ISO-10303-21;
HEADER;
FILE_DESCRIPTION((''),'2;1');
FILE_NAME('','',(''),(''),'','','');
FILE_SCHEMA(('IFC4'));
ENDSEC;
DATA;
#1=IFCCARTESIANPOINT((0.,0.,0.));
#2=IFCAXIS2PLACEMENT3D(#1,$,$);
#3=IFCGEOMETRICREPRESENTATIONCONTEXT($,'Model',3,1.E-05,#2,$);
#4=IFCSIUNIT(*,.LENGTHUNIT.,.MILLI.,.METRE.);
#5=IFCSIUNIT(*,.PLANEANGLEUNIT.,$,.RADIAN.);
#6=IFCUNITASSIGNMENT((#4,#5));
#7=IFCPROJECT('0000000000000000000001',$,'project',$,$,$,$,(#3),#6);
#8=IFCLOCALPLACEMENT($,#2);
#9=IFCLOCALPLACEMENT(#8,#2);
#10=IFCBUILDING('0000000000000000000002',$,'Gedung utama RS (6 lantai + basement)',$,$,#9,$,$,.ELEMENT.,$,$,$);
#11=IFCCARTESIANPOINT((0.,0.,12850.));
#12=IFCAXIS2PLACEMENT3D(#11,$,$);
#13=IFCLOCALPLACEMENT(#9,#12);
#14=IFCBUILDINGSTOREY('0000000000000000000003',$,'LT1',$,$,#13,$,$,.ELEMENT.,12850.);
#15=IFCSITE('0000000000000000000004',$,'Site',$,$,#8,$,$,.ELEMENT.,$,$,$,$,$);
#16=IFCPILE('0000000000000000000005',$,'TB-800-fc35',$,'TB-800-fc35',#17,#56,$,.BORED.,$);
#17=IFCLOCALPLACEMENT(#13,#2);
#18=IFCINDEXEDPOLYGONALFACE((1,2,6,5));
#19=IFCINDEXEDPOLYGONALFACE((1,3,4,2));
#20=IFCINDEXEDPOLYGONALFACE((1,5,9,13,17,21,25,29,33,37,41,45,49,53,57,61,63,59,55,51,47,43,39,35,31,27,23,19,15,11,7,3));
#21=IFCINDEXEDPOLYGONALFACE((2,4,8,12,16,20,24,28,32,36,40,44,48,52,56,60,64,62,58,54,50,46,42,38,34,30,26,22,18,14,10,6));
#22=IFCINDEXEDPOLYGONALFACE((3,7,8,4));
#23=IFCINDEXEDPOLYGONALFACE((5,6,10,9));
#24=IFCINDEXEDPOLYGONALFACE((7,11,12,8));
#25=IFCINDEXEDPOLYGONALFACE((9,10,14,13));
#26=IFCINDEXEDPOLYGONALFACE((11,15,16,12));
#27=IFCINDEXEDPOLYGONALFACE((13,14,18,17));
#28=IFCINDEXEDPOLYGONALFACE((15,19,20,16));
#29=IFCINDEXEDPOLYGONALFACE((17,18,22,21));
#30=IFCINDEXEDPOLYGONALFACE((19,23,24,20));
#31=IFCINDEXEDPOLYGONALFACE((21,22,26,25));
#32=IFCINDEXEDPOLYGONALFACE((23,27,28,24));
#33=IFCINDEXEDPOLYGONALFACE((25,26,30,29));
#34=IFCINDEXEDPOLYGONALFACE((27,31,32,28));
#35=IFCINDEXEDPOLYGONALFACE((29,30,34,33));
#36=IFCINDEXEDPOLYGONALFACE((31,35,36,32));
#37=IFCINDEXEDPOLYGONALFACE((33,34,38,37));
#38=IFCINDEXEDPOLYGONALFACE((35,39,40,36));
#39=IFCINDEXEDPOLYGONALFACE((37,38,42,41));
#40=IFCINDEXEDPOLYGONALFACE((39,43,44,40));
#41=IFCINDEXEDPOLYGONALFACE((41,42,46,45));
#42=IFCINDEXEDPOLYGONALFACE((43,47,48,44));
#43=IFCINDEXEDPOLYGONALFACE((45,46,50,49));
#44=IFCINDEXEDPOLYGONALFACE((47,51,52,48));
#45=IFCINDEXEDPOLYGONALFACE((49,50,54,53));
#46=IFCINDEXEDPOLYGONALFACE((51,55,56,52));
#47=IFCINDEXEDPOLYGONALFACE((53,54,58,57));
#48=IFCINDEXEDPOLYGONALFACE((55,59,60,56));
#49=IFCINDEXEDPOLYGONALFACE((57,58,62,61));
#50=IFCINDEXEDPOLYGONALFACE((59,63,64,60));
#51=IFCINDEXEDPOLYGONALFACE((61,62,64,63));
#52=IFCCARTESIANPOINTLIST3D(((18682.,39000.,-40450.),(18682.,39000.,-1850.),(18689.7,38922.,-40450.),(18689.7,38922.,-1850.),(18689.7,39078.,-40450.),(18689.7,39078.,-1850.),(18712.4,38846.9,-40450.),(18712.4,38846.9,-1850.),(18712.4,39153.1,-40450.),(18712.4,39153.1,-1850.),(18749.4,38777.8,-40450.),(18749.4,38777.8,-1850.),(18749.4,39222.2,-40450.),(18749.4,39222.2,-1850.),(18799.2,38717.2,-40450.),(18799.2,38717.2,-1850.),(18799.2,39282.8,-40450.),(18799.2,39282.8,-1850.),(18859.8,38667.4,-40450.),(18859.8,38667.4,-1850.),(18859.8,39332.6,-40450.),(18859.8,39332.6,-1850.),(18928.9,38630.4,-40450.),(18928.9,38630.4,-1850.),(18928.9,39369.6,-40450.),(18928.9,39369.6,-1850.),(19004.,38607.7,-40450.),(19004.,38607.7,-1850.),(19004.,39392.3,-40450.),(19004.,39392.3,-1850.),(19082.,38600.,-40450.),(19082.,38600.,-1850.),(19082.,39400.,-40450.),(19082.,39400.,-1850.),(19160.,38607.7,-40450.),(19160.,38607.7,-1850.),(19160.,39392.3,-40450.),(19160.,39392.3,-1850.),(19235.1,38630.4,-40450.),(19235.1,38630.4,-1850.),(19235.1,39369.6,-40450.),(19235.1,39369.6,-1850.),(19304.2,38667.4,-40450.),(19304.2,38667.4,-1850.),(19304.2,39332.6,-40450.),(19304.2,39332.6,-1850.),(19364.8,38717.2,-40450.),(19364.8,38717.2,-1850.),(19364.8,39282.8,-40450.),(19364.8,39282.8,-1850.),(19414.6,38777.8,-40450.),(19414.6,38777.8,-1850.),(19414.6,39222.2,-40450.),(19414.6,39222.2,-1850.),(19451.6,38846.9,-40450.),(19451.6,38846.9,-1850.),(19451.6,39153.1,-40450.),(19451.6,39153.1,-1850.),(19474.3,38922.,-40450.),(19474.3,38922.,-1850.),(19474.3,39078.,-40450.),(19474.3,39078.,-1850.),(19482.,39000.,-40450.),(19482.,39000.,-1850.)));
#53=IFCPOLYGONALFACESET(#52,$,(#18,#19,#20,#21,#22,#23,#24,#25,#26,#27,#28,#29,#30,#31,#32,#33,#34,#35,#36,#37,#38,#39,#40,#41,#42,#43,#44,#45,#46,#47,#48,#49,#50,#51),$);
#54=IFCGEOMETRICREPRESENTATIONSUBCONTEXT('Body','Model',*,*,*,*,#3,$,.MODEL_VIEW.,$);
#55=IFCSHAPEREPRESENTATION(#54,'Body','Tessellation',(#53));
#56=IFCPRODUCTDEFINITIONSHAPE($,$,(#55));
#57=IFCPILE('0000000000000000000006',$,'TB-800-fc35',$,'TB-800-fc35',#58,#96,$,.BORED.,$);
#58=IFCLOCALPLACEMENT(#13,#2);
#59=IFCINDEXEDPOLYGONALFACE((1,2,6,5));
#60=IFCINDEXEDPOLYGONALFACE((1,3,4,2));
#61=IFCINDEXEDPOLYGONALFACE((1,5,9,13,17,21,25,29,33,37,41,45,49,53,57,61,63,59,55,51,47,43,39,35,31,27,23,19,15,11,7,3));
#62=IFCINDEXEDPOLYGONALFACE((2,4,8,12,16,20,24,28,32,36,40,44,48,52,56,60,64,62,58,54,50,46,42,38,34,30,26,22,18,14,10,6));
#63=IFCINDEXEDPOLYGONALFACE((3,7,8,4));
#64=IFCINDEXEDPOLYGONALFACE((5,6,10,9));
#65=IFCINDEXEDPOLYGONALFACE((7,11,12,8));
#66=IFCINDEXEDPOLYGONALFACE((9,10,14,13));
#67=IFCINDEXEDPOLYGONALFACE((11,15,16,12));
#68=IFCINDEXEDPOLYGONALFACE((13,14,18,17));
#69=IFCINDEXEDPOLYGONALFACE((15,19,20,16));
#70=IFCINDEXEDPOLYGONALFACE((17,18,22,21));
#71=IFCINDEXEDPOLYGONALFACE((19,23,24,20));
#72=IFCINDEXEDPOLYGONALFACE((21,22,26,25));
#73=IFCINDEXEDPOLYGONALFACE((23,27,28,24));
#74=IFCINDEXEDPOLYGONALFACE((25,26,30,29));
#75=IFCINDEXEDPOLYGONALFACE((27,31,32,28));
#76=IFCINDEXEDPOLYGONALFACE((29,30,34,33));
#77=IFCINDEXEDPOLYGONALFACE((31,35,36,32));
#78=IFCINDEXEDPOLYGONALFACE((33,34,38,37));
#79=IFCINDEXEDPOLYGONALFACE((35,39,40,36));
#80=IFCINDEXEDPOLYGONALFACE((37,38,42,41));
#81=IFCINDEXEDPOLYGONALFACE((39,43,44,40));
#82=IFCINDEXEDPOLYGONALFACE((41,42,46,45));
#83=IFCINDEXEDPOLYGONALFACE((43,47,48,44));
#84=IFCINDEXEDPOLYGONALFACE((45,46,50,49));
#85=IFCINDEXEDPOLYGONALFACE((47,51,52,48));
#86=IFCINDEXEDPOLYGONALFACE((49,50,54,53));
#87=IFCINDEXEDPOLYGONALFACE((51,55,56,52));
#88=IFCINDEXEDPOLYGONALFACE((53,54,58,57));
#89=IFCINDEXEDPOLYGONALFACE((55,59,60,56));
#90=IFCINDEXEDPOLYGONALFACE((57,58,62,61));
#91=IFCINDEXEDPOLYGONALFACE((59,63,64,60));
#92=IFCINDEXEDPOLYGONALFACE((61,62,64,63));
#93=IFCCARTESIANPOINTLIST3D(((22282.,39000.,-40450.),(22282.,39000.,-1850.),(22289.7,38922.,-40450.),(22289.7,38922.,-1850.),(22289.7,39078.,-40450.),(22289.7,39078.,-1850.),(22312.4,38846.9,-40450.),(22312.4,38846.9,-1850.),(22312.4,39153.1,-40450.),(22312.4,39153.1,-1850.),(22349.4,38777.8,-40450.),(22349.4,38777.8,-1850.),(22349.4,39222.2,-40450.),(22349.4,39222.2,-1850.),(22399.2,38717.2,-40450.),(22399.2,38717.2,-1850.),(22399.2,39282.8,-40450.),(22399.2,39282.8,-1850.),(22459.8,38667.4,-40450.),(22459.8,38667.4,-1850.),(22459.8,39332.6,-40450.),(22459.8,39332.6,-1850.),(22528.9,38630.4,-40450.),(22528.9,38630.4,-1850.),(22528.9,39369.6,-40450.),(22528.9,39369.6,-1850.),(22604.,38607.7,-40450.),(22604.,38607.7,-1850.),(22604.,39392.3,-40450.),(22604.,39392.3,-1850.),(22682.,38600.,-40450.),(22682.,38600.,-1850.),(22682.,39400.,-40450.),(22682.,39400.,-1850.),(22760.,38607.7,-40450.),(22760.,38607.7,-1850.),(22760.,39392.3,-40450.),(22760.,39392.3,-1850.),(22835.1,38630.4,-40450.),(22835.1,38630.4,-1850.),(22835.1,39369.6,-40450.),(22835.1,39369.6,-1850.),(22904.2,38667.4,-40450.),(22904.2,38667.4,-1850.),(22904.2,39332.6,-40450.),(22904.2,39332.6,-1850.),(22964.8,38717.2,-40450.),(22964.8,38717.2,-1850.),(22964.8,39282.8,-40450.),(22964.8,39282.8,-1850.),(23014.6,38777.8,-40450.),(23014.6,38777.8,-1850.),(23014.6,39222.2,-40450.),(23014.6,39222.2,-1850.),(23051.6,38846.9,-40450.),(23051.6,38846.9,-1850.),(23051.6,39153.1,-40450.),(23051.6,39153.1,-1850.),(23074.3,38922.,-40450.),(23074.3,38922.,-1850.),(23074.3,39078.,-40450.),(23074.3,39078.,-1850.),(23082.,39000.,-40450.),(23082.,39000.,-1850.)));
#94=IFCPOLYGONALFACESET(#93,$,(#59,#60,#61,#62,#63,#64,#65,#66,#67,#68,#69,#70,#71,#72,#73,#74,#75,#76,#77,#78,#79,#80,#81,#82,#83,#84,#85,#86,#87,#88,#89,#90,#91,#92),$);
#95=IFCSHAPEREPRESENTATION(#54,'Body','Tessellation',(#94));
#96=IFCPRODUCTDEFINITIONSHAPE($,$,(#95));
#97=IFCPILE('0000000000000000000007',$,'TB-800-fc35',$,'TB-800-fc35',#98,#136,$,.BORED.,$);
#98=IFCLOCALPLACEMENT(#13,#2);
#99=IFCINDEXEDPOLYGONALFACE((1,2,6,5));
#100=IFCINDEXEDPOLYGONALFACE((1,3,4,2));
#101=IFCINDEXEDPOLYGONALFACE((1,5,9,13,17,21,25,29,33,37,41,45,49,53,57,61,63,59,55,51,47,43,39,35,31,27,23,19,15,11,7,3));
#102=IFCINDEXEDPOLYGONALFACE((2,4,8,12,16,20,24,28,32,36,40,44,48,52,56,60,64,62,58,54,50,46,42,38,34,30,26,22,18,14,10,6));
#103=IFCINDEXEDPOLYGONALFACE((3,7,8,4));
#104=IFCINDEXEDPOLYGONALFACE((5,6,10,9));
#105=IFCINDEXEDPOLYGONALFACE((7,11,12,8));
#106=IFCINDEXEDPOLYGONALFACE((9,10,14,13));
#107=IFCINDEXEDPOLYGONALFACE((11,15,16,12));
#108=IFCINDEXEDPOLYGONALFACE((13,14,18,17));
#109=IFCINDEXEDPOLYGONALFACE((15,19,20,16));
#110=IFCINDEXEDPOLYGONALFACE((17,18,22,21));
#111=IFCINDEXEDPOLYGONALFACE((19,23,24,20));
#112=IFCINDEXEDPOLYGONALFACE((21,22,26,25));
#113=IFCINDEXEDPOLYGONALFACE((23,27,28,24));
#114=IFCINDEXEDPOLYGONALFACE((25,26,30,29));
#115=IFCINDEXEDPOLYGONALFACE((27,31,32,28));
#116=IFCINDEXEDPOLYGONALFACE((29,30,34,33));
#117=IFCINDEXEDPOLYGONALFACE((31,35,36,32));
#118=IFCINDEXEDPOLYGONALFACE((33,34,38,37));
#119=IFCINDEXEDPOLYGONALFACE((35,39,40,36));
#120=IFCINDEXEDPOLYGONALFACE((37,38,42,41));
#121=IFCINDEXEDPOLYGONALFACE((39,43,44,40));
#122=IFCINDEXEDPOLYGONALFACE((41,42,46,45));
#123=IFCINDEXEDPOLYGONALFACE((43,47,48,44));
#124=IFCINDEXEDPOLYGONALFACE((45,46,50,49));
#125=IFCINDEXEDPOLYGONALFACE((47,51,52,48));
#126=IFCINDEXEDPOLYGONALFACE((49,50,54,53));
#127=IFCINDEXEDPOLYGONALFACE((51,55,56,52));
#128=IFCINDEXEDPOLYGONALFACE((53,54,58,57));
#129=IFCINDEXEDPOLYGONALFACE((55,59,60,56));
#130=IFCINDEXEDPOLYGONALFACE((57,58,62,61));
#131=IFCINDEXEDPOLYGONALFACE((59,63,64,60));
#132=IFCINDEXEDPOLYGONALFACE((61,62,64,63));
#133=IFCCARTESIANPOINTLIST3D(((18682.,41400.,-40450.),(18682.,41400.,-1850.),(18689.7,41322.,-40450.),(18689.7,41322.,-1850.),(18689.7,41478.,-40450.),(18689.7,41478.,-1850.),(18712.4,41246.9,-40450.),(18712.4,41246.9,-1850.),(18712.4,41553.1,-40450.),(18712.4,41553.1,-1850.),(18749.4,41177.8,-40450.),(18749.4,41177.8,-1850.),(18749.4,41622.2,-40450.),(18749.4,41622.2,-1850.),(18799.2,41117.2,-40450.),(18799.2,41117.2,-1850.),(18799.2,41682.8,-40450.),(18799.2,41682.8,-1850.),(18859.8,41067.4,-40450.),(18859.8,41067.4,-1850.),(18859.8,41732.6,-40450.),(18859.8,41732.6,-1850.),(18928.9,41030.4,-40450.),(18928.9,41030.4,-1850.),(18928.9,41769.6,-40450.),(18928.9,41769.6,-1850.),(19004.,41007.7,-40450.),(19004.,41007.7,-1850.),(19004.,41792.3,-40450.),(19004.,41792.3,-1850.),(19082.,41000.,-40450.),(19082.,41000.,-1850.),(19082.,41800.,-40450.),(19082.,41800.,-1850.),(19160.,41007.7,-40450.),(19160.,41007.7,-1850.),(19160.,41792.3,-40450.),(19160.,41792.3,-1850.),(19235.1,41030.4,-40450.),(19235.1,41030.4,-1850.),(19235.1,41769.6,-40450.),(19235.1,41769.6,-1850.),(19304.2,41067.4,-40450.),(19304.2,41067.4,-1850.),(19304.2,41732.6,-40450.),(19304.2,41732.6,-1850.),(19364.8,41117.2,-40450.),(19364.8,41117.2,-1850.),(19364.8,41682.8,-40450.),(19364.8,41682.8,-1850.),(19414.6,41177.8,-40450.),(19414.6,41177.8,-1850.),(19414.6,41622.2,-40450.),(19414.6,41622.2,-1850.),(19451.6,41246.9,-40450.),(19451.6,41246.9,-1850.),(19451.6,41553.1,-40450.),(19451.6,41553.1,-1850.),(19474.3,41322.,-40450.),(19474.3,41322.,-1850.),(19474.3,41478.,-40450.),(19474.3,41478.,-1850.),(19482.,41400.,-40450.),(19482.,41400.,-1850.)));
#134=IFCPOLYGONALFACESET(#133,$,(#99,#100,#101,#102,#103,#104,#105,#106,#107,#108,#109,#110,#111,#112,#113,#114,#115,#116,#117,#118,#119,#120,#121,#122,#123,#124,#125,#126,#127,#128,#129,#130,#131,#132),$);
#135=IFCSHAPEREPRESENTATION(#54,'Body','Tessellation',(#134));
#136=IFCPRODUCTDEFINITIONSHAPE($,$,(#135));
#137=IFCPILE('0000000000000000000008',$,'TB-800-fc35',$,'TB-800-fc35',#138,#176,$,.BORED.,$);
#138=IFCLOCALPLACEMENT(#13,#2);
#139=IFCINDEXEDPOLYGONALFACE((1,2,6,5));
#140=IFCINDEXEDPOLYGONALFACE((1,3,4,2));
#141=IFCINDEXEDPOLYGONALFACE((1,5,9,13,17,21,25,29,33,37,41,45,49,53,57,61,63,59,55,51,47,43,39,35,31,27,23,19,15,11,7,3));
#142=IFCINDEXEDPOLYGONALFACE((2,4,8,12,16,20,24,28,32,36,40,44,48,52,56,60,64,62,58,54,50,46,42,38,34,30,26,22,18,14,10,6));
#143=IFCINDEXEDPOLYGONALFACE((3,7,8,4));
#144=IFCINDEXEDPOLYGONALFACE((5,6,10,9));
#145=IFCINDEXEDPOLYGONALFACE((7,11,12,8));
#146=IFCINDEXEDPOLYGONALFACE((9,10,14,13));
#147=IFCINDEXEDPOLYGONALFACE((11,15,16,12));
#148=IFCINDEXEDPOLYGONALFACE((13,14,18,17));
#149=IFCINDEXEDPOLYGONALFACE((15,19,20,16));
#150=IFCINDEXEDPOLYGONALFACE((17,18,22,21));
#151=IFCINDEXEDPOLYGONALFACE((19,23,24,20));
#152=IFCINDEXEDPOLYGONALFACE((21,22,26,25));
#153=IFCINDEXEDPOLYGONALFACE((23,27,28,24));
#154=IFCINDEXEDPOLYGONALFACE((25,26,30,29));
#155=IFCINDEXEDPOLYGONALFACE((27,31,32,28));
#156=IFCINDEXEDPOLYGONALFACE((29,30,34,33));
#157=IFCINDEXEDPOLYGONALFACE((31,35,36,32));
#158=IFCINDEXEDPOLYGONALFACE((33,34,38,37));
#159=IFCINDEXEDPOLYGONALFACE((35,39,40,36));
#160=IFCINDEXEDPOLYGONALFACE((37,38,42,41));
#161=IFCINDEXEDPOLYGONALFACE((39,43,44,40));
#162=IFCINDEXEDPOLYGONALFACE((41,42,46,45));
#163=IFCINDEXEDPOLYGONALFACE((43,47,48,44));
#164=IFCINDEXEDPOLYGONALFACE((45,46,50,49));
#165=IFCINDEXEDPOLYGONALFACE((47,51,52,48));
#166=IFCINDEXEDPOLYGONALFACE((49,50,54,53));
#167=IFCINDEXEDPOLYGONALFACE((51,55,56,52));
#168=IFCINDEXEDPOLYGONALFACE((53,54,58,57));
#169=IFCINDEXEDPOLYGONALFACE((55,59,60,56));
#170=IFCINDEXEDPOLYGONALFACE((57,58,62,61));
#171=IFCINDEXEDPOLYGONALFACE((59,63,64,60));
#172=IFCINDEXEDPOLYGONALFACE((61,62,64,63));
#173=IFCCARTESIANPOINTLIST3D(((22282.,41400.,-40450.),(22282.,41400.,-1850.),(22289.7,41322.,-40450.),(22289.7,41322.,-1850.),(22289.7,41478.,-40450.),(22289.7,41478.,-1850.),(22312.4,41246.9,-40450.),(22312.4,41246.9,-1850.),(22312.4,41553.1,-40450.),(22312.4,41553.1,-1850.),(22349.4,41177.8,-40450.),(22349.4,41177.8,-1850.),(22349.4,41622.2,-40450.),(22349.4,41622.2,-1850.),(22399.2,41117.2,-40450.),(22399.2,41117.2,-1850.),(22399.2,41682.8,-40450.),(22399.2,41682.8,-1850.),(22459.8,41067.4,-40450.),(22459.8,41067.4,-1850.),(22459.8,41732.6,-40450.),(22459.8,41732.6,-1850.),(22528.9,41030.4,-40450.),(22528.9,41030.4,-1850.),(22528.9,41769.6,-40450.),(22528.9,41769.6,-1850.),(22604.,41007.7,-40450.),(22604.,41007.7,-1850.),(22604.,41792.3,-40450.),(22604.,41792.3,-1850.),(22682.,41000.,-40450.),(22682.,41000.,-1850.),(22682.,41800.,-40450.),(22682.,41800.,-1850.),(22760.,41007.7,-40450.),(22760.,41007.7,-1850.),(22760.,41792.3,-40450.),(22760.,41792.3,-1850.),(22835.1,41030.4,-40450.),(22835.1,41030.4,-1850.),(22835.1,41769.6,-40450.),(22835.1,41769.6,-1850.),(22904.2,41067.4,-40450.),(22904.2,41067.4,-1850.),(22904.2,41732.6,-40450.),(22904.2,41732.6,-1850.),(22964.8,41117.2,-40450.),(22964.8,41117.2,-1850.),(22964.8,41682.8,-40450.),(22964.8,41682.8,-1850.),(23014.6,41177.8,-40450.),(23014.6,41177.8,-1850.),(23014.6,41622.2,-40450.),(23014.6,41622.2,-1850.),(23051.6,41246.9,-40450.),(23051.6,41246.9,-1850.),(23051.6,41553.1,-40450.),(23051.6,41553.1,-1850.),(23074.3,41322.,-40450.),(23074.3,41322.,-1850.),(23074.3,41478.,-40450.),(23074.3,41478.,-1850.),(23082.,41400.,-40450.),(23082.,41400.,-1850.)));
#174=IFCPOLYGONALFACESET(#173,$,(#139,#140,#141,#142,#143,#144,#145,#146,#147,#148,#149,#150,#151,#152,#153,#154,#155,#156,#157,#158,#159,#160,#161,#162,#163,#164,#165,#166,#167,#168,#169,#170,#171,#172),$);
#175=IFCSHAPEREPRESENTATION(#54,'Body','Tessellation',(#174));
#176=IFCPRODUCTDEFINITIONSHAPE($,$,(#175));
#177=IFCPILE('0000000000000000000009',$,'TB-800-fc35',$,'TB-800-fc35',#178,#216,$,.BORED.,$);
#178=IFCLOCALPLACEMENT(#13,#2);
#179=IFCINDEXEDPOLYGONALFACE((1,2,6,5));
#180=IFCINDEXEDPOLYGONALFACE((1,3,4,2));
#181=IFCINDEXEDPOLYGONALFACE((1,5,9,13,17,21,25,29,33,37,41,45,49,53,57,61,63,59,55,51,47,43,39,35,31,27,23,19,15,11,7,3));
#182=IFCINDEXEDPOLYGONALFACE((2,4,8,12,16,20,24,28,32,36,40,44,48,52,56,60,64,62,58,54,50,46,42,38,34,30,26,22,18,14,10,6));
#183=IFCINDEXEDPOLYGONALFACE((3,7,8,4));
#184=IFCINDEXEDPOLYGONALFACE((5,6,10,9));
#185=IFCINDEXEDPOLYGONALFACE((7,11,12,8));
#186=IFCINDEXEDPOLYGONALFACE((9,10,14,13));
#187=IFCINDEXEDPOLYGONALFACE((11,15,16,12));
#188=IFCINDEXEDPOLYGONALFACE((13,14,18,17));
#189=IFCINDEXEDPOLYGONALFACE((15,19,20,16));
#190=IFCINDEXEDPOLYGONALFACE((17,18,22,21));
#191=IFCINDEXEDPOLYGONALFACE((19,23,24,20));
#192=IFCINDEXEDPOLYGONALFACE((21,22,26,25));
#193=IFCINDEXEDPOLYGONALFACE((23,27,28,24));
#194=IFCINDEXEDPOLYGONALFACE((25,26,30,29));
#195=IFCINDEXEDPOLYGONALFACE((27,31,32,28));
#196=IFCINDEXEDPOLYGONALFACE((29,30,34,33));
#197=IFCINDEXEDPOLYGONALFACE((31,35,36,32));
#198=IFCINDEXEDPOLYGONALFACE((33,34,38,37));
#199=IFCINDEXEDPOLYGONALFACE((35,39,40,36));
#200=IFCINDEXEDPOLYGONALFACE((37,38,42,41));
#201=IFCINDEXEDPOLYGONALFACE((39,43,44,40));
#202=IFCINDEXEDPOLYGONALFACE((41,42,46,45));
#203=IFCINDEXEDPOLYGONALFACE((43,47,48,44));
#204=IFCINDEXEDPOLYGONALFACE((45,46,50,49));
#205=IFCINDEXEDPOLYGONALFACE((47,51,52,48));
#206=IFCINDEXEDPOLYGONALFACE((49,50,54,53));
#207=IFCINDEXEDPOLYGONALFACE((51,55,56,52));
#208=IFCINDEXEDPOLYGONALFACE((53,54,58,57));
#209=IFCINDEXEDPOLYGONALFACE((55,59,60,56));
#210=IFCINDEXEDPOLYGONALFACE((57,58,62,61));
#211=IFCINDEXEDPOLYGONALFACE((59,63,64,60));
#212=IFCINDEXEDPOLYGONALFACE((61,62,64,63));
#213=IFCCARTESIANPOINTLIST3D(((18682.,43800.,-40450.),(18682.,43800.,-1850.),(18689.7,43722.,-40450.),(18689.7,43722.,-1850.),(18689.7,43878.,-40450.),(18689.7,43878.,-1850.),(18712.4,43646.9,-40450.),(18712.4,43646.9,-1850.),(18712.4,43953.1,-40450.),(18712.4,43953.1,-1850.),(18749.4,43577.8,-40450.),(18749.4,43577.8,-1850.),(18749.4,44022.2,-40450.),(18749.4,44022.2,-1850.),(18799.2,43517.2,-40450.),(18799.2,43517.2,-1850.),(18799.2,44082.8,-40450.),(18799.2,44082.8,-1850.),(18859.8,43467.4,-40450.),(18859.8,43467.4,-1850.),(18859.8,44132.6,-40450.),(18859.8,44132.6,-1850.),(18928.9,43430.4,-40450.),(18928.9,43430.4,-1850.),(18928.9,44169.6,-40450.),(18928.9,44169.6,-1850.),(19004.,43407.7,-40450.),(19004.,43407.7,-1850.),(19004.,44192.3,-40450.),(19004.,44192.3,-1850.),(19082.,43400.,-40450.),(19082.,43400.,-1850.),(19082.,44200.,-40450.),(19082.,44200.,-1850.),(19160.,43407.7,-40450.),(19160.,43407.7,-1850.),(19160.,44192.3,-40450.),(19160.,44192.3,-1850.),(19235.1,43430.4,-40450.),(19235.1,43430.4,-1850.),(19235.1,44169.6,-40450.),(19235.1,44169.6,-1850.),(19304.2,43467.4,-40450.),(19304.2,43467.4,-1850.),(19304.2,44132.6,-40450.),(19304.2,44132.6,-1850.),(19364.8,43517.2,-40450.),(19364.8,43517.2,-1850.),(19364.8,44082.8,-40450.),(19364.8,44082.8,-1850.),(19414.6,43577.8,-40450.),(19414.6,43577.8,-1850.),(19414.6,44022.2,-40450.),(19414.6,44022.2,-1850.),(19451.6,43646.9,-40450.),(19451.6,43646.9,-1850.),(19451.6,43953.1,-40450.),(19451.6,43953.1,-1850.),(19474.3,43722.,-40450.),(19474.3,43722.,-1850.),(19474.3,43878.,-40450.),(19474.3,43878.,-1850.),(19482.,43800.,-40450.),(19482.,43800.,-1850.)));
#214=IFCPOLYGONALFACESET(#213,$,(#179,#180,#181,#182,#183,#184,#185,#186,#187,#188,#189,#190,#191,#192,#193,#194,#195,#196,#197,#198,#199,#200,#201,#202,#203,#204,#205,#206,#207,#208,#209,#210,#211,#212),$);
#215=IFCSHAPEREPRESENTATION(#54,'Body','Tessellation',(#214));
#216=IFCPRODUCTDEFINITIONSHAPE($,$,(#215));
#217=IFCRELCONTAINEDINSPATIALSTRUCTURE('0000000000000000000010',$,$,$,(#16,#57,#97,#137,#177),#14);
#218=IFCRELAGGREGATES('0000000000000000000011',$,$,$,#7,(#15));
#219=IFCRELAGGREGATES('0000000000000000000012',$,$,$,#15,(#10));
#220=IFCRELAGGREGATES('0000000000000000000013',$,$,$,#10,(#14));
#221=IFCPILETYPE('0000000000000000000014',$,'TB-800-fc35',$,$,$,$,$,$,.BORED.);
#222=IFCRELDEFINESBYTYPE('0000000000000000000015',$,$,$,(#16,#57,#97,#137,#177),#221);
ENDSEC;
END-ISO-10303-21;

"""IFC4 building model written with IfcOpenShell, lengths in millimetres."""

from ifc_helpers import new_model, si_unit, frame, origin, origin_2d, place, context, subcontext, project, spatial, circle, extrude, material_profile, profile_set, profile_usage, type_object, element, save


model = new_model("IFC4")

# Units and contexts
model_context = context("Model", 3, precision=1e-05, world=origin())
body_context = subcontext(model_context, "Body", "Model", "MODEL_VIEW")
ifc_project = project(units=[si_unit("LENGTHUNIT", "METRE", prefix="MILLI"), si_unit("PLANEANGLEUNIT", "RADIAN")], contexts=[model_context])

# Site, building, storey
site_placement = place(None, origin())
site = spatial("IfcSite", under=ifc_project, at=site_placement, Name="Site", CompositionType="ELEMENT")
building_placement = place(site_placement, origin())
building = spatial("IfcBuilding", under=site, at=building_placement, Name="Gedung utama RS (6 lantai + basement)", CompositionType="ELEMENT")
storey_placement = place(building_placement, frame((0.0, 0.0, 12850.0)))
storey = spatial("IfcBuildingStorey", under=building, at=storey_placement, Name="LT1", CompositionType="ELEMENT", Elevation=12850.0)

# Piles
ifc_material_profile_1 = material_profile(None, circle(Radius=400.0, at=origin_2d()), Name="TB-800-fc35")
ifc_profile_set_1 = profile_set([ifc_material_profile_1], Name="TB-800-fc35")
ifc_profile_usage_1 = profile_usage(ifc_profile_set_1, cardinal=5)
pile_type = type_object("IfcPileType", Name="TB-800-fc35", PredefinedType="BORED", material=ifc_profile_set_1)
for number, where, z_axis, x_axis, name in (
    (1, (19082.0, 39000.0, -40450.0), (0.0, 0.0, 1.0), (1.0, 0.0, 0.0), "TB-800-fc35"),
    (2, (22682.0, 39000.0, -40450.0), (0.0, 0.0, 1.0), (1.0, 0.0, 0.0), "TB-800-fc35"),
    (3, (19082.0, 41400.0, -40450.0), (0.0, 0.0, 1.0), (1.0, 0.0, 0.0), "TB-800-fc35"),
    (4, (22682.0, 41400.0, -40450.0), (0.0, 0.0, 1.0), (1.0, 0.0, 0.0), "TB-800-fc35"),
    (5, (19082.0, 43800.0, -40450.0), (0.0, 0.0, 1.0), (1.0, 0.0, 0.0), "TB-800-fc35"),
):
    element("IfcPile", number, at=place(storey_placement, frame(where, z_axis=z_axis, x_axis=x_axis)), inside=storey, type_object=pile_type, material=ifc_profile_usage_1, Name=name, ObjectType="TB-800-fc35", PredefinedType="BORED", context=body_context, shape_type="SweptSolid", body=[
        extrude(circle(Radius=400.0, at=origin_2d()), origin(), (0.0, 0.0, 1.0), 38600.0),
    ])

save(model, "model.ifc")
